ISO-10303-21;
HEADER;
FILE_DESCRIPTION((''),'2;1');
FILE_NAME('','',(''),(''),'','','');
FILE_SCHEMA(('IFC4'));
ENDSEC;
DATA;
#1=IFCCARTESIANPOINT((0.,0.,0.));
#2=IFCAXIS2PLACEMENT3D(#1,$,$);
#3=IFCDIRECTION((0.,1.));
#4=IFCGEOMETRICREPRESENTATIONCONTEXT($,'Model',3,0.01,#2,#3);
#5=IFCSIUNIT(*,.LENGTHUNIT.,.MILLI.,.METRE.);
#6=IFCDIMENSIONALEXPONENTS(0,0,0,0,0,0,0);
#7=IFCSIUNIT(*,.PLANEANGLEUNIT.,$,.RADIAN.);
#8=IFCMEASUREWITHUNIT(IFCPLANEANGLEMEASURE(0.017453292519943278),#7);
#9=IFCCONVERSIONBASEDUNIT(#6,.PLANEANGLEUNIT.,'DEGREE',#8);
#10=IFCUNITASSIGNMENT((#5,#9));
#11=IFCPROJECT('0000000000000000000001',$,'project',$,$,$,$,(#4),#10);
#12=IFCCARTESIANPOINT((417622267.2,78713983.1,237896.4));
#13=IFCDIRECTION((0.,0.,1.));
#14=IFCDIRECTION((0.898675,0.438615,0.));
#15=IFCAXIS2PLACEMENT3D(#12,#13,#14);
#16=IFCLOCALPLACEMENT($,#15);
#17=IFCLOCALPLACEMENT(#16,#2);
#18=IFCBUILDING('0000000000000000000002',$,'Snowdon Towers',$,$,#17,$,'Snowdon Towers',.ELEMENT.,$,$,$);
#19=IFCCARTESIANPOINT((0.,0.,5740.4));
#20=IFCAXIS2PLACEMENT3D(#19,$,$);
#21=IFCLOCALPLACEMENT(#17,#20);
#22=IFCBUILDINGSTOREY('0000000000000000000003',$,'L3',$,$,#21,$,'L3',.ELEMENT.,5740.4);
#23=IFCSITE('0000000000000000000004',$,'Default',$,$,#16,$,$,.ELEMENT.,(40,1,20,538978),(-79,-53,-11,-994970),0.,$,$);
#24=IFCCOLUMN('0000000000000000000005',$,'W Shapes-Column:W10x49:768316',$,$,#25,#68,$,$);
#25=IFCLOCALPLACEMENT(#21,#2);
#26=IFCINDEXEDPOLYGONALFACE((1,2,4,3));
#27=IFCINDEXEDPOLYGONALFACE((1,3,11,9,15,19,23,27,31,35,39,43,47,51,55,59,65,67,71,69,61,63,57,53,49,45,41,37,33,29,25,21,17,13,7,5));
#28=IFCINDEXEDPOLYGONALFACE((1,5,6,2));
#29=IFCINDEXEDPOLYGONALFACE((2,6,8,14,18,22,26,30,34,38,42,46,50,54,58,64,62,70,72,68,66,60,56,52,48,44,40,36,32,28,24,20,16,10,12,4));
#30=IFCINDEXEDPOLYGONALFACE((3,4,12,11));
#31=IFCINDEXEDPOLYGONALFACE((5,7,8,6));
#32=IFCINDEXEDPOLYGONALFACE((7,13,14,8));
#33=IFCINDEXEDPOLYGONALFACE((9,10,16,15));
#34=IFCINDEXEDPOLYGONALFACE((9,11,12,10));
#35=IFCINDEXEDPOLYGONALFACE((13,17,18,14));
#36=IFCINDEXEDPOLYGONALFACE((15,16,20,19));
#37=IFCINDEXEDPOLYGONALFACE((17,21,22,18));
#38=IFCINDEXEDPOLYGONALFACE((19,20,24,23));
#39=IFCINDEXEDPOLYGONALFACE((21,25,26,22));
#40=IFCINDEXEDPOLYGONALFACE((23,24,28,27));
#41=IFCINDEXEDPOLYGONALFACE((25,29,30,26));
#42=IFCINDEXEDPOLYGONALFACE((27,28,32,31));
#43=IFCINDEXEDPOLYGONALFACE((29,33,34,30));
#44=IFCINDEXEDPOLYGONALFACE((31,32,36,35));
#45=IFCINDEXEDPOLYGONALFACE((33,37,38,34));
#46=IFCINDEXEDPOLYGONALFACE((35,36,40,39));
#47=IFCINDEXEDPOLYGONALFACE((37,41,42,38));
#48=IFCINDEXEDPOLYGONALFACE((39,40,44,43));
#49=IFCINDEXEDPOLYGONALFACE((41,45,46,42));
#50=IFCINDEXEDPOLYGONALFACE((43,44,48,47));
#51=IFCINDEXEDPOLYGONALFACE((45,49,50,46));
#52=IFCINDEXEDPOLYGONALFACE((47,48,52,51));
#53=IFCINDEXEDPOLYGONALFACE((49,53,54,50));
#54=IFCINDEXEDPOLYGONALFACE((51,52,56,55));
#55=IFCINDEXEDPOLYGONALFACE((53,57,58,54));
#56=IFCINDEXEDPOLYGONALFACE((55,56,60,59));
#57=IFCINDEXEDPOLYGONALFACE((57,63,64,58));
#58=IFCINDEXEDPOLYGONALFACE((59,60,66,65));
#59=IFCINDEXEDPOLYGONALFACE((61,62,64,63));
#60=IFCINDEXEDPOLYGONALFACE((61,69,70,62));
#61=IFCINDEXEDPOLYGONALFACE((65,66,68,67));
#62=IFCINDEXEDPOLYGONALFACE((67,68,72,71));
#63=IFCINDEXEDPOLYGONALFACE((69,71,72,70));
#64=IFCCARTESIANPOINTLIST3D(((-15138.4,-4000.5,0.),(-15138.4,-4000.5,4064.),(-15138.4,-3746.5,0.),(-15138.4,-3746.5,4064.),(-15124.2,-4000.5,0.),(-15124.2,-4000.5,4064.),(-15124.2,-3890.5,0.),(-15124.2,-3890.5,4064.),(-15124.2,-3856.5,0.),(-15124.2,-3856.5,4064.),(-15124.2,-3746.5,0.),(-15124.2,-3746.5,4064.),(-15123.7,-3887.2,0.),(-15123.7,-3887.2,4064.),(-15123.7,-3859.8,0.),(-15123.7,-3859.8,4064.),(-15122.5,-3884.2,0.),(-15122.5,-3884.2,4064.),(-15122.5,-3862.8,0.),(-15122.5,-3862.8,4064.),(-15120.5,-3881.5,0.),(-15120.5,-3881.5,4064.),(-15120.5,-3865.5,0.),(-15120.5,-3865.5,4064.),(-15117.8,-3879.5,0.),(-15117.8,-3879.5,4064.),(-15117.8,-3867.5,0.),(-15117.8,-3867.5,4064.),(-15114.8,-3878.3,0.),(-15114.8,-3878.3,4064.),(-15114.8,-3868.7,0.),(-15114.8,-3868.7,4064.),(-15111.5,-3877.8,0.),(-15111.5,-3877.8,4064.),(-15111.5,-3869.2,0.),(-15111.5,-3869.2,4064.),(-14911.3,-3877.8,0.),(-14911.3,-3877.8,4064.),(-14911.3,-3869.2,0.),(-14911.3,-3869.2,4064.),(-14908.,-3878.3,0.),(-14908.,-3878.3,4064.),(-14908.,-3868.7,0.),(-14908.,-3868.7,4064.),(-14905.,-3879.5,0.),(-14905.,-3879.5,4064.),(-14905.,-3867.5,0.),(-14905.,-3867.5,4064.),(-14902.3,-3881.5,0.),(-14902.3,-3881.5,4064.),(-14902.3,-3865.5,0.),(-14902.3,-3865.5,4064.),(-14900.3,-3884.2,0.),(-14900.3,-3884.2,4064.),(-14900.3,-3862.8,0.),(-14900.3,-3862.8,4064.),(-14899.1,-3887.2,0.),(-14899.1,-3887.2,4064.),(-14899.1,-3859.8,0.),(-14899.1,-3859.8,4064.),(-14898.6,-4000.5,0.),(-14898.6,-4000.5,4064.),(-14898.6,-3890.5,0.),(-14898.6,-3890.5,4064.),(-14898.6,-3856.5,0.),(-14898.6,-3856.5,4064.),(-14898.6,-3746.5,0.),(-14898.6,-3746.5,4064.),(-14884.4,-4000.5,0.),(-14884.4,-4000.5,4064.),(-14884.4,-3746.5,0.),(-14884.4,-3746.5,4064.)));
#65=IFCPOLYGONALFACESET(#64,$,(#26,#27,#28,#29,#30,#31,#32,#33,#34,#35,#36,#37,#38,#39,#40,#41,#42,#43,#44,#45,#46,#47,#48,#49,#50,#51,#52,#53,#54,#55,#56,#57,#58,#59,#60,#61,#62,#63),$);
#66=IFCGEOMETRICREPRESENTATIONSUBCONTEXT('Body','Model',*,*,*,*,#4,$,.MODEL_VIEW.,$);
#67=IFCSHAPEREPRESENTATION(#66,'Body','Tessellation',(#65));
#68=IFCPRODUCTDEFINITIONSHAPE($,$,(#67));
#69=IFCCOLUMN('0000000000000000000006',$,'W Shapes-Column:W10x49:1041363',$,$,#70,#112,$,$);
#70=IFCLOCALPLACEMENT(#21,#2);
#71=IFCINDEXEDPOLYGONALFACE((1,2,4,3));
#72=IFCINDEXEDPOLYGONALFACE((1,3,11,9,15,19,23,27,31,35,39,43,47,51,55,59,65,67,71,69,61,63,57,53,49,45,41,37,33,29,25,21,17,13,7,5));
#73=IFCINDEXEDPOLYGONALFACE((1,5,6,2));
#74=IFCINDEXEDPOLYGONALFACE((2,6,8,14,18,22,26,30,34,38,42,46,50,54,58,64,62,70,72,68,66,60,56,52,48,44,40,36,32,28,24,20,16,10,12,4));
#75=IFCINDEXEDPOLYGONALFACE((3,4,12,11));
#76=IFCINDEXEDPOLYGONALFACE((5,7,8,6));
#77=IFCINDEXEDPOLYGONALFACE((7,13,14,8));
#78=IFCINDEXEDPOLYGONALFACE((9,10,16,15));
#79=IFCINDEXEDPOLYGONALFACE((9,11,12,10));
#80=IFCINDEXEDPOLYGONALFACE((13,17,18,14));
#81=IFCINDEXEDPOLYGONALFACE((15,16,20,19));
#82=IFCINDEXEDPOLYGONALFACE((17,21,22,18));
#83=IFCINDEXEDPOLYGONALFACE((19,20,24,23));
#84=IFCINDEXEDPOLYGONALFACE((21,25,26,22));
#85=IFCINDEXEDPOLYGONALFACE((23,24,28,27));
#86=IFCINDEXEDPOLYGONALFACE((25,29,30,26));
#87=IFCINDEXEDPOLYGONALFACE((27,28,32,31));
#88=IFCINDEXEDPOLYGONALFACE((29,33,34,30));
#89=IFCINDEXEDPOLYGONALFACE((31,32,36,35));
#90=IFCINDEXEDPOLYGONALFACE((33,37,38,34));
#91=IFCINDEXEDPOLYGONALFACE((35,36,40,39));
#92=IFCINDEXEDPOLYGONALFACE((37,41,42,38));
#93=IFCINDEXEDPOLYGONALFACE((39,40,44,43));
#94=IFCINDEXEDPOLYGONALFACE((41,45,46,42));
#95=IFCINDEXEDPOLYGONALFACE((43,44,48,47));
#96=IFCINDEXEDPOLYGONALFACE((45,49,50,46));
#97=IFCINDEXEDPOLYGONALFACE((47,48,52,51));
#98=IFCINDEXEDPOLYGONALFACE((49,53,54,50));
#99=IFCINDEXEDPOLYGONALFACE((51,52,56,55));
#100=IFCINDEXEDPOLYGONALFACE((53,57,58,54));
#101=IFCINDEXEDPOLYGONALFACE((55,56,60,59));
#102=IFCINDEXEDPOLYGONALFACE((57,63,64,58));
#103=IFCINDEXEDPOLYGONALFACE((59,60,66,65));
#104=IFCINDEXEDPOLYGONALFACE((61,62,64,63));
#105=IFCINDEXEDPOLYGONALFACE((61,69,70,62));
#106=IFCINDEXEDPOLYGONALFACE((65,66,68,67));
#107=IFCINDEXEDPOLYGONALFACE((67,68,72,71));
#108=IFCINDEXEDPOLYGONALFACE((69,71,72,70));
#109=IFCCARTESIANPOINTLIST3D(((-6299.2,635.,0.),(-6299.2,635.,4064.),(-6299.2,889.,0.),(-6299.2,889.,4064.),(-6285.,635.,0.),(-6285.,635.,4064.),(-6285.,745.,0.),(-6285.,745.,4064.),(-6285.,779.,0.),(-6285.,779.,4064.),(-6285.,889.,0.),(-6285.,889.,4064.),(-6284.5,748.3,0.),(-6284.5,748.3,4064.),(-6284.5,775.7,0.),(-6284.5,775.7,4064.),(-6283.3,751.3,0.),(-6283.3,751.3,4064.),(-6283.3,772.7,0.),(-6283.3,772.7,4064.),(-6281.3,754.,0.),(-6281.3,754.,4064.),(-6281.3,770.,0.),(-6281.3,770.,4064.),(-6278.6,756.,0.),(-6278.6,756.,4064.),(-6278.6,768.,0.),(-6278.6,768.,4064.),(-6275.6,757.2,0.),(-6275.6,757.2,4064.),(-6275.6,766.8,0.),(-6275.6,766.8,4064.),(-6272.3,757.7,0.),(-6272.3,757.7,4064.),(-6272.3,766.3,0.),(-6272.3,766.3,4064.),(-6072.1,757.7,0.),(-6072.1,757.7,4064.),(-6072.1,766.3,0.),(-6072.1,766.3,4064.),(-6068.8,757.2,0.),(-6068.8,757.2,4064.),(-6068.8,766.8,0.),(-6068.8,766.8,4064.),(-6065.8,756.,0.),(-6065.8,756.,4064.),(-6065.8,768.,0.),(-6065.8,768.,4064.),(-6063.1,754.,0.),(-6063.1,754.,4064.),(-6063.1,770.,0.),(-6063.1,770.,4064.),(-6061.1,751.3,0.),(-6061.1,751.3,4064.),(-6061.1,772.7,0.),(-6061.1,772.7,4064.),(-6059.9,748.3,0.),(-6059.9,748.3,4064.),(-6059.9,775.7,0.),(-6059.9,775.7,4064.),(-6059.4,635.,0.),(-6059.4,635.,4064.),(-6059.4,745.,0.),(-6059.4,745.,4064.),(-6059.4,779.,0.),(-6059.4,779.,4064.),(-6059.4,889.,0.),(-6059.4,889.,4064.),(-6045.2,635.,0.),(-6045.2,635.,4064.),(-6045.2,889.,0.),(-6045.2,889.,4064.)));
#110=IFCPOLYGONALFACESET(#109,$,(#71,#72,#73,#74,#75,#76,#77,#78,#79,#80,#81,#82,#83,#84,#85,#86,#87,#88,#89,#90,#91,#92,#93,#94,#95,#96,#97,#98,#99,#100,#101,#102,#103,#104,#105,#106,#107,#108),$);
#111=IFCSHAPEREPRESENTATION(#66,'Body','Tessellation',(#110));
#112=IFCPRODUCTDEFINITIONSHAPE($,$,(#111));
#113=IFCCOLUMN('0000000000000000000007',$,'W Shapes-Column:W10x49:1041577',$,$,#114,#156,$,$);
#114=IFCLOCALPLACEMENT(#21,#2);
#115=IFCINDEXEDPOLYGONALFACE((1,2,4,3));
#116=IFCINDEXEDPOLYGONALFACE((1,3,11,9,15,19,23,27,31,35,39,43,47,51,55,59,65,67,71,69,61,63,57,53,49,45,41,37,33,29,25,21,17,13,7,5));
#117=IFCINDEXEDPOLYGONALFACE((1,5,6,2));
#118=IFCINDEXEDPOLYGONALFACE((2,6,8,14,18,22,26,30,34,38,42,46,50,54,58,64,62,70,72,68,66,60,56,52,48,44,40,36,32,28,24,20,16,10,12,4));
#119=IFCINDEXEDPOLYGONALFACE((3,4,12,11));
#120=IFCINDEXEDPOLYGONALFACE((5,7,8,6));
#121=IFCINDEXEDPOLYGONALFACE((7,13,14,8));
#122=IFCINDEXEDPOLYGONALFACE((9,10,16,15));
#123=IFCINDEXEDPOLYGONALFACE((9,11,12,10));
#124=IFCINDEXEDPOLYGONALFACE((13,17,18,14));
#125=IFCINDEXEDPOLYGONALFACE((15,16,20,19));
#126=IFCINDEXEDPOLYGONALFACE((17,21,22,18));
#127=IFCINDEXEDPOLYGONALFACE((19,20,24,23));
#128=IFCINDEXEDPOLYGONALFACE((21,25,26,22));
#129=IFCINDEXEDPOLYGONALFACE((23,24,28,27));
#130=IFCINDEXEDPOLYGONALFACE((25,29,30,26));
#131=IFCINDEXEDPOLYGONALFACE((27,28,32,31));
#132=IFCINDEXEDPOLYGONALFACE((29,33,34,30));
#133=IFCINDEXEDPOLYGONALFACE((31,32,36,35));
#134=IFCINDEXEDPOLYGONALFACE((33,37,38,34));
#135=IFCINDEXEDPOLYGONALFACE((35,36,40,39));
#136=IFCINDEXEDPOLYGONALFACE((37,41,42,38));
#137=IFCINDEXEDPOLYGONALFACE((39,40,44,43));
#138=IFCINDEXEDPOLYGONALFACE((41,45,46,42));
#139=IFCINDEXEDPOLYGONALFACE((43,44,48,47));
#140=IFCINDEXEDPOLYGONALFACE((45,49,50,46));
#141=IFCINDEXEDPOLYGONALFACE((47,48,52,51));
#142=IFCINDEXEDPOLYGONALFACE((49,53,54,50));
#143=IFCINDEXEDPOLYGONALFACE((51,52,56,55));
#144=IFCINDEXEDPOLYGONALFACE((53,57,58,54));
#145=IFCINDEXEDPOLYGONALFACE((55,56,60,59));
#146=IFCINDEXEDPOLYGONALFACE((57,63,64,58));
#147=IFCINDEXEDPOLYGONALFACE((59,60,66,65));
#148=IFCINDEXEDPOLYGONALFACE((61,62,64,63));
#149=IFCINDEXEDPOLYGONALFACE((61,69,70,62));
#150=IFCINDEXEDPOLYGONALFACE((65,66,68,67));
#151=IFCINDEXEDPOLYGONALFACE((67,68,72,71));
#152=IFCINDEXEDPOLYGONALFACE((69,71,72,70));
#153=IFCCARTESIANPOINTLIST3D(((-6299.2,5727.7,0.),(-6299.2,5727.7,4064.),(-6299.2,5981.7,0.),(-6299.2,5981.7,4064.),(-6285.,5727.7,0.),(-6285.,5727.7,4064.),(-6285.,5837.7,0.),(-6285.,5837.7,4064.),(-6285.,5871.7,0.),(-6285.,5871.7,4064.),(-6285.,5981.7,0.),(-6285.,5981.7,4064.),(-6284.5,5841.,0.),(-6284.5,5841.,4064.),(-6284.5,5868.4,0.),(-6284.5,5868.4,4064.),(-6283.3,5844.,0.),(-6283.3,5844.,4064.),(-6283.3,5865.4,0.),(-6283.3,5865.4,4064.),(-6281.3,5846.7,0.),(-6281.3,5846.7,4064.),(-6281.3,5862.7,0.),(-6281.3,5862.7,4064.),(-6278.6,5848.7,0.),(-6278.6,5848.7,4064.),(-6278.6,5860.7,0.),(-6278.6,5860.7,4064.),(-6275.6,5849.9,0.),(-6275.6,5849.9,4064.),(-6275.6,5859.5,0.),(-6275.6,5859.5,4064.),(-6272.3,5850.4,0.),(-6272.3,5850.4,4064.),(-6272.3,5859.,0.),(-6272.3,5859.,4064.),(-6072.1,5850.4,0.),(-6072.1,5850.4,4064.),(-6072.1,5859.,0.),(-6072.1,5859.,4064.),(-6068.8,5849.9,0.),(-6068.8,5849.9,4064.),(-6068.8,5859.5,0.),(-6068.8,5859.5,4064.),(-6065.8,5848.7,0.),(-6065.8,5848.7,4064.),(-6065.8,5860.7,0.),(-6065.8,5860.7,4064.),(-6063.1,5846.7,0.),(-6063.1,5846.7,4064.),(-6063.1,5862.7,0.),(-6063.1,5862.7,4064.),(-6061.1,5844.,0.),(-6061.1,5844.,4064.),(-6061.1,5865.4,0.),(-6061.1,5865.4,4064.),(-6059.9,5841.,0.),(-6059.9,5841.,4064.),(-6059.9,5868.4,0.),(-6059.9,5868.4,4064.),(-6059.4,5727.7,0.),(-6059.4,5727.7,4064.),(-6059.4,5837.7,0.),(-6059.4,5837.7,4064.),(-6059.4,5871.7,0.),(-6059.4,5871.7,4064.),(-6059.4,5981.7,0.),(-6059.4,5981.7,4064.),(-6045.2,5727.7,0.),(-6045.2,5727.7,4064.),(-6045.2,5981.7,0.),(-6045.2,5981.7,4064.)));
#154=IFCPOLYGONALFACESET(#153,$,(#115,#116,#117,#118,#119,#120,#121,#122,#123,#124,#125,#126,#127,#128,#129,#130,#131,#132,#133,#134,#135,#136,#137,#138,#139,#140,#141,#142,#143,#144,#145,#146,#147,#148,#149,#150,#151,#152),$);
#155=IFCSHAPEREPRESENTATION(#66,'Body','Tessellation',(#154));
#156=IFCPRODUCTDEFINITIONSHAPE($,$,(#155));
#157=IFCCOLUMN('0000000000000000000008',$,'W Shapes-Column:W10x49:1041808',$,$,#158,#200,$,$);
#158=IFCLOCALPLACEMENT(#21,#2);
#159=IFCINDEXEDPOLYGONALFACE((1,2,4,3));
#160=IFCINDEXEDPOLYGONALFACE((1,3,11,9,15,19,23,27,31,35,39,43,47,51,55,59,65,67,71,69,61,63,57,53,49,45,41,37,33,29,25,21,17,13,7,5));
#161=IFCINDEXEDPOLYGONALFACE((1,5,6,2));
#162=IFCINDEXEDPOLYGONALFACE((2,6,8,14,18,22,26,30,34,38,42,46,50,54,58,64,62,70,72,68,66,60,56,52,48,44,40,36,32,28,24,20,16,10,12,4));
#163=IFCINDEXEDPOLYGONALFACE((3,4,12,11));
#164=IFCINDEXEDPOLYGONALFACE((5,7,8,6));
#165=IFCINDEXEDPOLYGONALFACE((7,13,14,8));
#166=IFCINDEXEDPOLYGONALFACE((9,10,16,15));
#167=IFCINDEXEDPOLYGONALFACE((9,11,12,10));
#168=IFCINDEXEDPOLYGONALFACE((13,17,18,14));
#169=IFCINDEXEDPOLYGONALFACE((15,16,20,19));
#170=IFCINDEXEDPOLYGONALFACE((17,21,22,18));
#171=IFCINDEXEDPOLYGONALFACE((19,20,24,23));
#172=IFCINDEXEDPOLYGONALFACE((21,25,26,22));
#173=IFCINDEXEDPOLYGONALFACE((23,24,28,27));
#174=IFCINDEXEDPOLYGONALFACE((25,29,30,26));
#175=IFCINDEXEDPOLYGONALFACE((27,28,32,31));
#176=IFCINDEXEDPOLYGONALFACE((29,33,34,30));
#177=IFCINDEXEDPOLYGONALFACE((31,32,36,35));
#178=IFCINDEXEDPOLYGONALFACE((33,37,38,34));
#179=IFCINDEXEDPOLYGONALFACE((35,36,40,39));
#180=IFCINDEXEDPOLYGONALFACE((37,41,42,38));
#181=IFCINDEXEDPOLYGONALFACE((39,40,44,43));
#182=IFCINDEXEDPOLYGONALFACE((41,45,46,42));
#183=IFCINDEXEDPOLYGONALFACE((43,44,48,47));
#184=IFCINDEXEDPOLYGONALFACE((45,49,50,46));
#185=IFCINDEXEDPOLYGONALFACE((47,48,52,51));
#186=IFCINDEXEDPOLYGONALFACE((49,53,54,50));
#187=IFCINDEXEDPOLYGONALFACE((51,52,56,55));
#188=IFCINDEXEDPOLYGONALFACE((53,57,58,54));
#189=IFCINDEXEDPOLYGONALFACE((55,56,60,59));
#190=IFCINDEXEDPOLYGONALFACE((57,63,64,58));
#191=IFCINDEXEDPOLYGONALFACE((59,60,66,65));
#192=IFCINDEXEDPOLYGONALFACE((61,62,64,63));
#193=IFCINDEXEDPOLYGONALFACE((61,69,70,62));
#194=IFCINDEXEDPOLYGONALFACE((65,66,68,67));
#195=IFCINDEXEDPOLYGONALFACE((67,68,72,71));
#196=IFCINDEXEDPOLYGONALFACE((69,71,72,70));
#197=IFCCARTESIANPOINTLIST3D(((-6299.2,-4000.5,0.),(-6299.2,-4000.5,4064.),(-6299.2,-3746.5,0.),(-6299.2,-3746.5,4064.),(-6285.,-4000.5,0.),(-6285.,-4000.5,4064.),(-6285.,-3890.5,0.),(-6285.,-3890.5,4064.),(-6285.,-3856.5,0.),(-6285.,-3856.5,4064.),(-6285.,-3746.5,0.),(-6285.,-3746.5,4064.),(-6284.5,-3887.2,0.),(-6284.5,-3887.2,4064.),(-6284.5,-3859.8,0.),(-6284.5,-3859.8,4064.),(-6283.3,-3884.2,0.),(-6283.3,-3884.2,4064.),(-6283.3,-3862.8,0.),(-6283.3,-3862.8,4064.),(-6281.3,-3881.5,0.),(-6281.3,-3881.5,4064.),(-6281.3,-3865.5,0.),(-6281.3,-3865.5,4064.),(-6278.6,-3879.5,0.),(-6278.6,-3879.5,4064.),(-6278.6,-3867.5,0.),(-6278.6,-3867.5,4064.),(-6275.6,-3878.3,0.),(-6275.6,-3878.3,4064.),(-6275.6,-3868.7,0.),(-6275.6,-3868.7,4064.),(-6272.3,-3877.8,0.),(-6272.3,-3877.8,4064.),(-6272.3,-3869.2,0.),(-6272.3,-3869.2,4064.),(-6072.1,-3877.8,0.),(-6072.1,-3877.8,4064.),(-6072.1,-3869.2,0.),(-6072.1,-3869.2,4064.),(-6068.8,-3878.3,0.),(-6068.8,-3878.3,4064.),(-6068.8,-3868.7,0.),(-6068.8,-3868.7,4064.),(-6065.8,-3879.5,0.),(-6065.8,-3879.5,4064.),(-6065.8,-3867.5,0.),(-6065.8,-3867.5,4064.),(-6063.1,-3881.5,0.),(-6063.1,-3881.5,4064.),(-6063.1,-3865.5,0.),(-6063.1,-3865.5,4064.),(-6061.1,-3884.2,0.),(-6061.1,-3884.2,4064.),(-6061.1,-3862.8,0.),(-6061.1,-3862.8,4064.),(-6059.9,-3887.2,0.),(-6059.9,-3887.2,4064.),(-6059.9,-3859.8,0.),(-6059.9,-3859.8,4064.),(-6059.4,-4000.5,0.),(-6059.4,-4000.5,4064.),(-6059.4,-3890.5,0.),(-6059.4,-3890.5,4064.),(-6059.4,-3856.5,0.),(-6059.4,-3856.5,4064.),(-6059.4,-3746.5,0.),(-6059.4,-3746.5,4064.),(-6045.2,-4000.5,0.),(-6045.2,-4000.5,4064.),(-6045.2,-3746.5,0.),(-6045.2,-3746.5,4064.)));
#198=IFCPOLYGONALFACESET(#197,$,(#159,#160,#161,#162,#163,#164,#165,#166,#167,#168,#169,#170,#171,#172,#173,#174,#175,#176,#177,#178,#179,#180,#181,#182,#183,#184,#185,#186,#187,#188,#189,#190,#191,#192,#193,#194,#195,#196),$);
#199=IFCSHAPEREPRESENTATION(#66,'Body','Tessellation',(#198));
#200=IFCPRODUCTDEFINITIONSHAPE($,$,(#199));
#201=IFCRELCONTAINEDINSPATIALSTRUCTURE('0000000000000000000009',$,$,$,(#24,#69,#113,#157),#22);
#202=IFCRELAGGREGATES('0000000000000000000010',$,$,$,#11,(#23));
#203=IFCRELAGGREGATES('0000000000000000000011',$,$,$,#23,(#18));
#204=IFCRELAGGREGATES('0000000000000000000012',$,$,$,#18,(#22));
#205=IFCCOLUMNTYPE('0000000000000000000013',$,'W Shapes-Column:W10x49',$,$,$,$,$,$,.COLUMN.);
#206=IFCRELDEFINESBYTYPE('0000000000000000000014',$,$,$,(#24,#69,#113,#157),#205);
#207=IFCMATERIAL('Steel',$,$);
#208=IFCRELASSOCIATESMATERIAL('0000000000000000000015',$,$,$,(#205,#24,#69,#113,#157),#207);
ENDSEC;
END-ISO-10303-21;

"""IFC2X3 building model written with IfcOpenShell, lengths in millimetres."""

from ifc_helpers import new_model, entity, si_unit, converted_unit, direction, frame, frame_2d, origin, place, context, subcontext, project, spatial, i_section, extrude, source, transform, mapped, material, type_object, type_shapes, element, save


model = new_model("IFC2X3")

# Units and contexts
model_context = context("Model", 3, precision=0.01, world=origin(), true_north=direction((0.0, 1.0)))
body_context = subcontext(model_context, "Body", "Model", "MODEL_VIEW")
ifc_project = project(units=[si_unit("LENGTHUNIT", "METRE", prefix="MILLI"), converted_unit("PLANEANGLEUNIT", "DEGREE", entity("IfcPlaneAngleMeasure", 0.017453292519943278), si_unit("PLANEANGLEUNIT", "RADIAN"), dimensions=[0, 0, 0, 0, 0, 0, 0])], contexts=[model_context])

# Site, building, storey
site_placement = place(None, frame((417622267.2, 78713983.1, 237896.4), z_axis=(0.0, 0.0, 1.0), x_axis=(0.898675, 0.438615, 0.0)))
site = spatial("IfcSite", under=ifc_project, at=site_placement, Name="Default", CompositionType="ELEMENT", RefLatitude=(40, 1, 20, 538978), RefLongitude=(-79, -53, -11, -994970), RefElevation=0.0)
building_placement = place(site_placement, origin())
building = spatial("IfcBuilding", under=site, at=building_placement, Name="Snowdon Towers", LongName="Snowdon Towers", CompositionType="ELEMENT")
storey_placement = place(building_placement, frame((0.0, 0.0, 5740.4)))
storey = spatial("IfcBuildingStorey", under=building, at=storey_placement, Name="L3", LongName="L3", CompositionType="ELEMENT", Elevation=5740.4)

# Columns
ifc_material_1 = material(Name="Steel")
column_type_1 = type_object("IfcColumnType", Name="W Shapes-Column:W10x49", PredefinedType="COLUMN", material=ifc_material_1)
shared_shape_1 = source(origin(), body_context, "Body", "SweptSolid", [
    extrude(i_section(OverallWidth=254.0, OverallDepth=254.0, WebThickness=8.6, FlangeThickness=14.2, FilletRadius=12.7, at=frame_2d((0.0, 0.0), x_axis=(1.0, 0.0))), frame((0.0, 0.0, 5740.4), z_axis=(0.0, 0.0, 1.0), x_axis=(-1.0, 0.0, 0.0)), (0.0, 0.0, 1.0), 4064.0),
])
type_shapes(column_type_1, [shared_shape_1])
for number, where, z_axis, x_axis, name in (
    (1, (-15011.4, -3873.5, -5740.4), (0.0, 0.0, 1.0), (0.0, 1.0, 0.0), "W Shapes-Column:W10x49:768316"),
    (2, (-6172.2, 762.0, -5740.4), (0.0, 0.0, 1.0), (0.0, 1.0, 0.0), "W Shapes-Column:W10x49:1041363"),
    (3, (-6172.2, 5854.7, -5740.4), (0.0, 0.0, 1.0), (0.0, 1.0, 0.0), "W Shapes-Column:W10x49:1041577"),
    (4, (-6172.2, -3873.5, -5740.4), (0.0, 0.0, 1.0), (0.0, 1.0, 0.0), "W Shapes-Column:W10x49:1041808"),
):
    element("IfcColumn", number, at=place(storey_placement, frame(where, z_axis=z_axis, x_axis=x_axis)), inside=storey, type_object=column_type_1, material=ifc_material_1, Name=name, context=body_context, shape_type="MappedRepresentation", body=[
        mapped(shared_shape_1, transform((0.0, 0.0, 0.0), scale=1.0)),
    ])

save(model, "model.ifc")
